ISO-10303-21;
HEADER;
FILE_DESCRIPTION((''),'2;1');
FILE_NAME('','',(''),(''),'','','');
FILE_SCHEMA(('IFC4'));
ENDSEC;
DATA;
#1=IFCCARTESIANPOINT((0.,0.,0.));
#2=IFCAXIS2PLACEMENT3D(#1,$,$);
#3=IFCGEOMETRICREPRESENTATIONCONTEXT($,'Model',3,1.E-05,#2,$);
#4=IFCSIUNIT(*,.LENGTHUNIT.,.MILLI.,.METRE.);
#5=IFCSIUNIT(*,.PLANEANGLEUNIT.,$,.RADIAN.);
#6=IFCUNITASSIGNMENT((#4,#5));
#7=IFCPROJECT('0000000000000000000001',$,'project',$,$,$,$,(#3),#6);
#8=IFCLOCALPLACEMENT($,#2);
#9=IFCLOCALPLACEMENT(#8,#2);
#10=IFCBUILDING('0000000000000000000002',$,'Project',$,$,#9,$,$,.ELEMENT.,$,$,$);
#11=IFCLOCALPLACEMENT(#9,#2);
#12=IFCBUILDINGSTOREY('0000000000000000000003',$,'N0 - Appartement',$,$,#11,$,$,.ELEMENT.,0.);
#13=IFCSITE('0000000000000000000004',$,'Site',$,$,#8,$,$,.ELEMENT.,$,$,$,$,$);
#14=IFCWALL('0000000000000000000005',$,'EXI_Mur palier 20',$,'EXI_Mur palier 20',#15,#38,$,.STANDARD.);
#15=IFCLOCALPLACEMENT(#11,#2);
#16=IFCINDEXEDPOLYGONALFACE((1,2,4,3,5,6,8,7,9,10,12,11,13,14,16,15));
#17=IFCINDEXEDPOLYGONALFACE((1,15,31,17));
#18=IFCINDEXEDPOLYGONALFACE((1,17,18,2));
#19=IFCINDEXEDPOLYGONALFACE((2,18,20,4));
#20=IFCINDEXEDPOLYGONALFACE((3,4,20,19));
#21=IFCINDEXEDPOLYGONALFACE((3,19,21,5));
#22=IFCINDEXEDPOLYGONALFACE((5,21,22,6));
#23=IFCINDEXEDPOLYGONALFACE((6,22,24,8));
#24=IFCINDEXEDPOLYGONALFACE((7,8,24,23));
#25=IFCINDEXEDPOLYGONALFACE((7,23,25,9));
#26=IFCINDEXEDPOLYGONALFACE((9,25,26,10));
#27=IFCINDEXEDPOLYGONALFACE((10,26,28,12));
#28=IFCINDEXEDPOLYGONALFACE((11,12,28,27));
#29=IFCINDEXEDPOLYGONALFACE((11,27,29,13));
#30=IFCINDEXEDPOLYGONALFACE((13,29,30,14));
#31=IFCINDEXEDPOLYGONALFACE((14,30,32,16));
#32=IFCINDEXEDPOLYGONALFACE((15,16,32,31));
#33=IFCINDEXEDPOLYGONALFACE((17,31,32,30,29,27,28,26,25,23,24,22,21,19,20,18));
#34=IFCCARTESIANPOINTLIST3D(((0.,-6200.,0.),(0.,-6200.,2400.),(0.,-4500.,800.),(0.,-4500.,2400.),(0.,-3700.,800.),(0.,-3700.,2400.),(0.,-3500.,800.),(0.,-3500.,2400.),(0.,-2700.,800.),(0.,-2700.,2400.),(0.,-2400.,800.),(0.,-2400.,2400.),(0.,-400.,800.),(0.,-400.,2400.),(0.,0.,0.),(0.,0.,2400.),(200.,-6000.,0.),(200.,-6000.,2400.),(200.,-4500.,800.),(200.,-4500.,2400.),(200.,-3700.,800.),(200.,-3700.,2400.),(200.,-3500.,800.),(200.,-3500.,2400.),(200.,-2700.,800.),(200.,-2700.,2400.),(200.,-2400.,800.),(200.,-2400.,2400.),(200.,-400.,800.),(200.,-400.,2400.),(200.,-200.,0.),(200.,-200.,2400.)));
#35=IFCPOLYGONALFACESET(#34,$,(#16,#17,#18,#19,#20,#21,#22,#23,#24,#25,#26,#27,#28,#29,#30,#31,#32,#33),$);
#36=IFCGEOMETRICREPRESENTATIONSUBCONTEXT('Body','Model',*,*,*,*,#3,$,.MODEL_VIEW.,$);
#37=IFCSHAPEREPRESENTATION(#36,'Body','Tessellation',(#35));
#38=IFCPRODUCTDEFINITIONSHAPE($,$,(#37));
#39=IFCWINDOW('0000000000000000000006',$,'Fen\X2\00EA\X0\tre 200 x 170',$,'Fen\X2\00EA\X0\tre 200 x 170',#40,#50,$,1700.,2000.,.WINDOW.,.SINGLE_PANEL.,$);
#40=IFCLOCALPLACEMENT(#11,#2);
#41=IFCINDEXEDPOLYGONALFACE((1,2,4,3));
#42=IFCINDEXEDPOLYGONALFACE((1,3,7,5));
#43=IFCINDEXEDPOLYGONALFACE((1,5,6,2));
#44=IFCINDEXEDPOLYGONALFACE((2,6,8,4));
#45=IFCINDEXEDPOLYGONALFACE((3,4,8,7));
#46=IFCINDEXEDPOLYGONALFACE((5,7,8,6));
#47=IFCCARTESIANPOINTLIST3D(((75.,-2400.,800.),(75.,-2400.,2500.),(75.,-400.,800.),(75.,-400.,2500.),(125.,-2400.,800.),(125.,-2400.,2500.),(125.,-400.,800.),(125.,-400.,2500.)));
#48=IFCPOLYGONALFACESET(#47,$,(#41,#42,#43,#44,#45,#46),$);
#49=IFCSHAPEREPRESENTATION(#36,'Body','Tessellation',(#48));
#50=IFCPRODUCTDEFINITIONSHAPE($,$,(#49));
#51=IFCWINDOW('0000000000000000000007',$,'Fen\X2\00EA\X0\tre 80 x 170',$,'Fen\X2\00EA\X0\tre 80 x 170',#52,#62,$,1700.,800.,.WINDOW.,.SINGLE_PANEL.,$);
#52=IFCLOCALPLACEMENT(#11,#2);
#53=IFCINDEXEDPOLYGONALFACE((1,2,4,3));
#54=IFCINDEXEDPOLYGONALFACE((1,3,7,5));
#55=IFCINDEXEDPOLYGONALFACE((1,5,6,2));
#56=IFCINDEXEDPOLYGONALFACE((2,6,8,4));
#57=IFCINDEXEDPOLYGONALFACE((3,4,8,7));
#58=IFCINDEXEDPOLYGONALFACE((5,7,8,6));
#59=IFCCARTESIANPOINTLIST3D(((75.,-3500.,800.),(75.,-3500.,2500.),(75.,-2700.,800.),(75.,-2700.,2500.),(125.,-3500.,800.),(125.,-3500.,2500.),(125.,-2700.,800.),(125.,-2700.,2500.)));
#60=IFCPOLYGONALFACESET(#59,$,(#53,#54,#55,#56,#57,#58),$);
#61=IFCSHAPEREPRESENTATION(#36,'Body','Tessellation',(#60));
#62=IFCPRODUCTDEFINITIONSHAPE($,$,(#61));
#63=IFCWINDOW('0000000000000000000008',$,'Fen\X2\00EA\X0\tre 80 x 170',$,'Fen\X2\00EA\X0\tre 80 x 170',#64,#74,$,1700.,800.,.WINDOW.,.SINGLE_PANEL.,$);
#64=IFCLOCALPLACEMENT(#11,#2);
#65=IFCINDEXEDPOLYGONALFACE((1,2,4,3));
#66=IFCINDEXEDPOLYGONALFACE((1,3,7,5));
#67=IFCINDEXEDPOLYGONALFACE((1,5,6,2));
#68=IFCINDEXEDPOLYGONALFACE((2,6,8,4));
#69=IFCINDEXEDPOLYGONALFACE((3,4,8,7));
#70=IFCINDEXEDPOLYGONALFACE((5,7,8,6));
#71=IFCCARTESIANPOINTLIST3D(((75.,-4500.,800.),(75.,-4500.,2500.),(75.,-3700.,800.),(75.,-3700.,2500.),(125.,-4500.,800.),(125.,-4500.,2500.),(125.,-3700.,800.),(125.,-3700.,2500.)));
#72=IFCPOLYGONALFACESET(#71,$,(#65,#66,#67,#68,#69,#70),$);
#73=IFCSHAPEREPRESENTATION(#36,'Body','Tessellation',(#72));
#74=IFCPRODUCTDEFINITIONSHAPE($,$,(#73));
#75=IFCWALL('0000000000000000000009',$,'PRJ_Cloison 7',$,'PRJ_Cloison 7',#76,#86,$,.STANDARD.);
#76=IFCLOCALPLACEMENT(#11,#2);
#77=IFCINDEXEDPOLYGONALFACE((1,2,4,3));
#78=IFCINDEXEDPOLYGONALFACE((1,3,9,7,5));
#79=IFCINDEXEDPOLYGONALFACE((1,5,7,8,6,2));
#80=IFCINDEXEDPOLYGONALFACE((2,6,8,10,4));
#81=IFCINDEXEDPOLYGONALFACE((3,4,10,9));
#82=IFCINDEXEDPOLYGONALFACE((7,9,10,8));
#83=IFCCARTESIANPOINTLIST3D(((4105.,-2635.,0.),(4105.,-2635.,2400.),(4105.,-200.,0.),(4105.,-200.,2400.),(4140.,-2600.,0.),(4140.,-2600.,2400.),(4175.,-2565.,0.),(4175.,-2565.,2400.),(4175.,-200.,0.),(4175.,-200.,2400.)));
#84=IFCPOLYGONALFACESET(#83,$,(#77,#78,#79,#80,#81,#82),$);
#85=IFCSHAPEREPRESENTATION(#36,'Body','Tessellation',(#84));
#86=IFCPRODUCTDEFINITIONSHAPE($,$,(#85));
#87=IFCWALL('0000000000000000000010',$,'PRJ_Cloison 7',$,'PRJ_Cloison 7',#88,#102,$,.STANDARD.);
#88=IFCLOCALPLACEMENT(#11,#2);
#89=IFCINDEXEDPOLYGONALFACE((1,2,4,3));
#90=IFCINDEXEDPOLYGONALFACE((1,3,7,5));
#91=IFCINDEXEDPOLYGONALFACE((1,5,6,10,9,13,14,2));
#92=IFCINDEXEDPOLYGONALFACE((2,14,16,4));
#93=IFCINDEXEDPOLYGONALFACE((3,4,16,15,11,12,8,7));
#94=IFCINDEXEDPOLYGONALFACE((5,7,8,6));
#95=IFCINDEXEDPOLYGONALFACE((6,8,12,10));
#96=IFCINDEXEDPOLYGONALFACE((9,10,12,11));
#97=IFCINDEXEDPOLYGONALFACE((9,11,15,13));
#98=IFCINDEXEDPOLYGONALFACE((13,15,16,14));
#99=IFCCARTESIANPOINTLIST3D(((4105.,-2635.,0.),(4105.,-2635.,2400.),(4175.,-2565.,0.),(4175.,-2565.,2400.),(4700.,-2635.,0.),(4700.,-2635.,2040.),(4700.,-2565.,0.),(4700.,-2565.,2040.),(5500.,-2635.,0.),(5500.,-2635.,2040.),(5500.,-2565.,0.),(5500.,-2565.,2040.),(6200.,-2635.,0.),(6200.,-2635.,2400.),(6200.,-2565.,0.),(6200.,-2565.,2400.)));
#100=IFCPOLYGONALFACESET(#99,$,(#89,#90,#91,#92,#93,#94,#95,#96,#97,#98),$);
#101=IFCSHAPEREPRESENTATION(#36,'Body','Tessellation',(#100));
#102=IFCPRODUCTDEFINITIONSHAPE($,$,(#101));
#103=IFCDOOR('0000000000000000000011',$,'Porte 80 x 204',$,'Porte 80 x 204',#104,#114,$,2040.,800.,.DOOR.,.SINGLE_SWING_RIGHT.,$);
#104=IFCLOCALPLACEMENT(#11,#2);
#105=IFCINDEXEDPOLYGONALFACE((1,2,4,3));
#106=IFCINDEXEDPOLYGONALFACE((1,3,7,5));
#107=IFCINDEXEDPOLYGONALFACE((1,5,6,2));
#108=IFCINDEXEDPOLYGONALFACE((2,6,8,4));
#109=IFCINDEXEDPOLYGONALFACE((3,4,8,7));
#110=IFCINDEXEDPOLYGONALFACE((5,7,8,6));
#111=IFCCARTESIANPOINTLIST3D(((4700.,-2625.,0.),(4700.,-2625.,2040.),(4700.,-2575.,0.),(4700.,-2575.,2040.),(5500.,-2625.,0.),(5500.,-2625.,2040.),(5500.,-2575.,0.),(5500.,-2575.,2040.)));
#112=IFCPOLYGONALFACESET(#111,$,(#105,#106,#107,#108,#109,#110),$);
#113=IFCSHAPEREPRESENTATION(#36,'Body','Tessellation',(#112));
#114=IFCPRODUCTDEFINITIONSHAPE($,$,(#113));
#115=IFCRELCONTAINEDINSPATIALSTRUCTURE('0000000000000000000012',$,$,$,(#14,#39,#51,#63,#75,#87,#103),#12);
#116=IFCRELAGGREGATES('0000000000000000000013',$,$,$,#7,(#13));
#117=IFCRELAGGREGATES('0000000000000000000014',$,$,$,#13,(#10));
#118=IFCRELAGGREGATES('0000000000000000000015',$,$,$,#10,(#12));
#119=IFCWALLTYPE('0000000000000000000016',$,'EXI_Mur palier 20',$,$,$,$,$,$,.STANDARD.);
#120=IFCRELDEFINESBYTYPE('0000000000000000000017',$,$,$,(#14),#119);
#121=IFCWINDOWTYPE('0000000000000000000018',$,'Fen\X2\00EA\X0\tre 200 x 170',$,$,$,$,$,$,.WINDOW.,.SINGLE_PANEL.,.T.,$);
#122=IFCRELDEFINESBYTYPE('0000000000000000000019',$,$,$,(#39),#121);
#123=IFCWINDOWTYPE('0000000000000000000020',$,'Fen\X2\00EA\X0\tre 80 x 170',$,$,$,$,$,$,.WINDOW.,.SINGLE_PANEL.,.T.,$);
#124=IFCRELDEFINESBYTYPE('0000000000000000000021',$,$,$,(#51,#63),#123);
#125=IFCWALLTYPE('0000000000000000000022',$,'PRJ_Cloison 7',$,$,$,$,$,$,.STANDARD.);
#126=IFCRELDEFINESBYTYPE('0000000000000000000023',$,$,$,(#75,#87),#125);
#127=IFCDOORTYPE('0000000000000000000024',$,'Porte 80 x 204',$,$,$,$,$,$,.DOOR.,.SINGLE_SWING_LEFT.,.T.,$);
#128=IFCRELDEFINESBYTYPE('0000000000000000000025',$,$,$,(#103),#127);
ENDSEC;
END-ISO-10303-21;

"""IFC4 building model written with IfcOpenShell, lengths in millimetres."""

from ifc_helpers import new_model, si_unit, frame, frame_2d, origin, place, context, subcontext, project, spatial, polyline, rectangle, outline, extrude, type_object, element, fill, save


model = new_model("IFC4")

# Units and contexts
model_context = context("Model", 3, precision=1e-05, world=origin())
body_context = subcontext(model_context, "Body", "Model", "MODEL_VIEW")
ifc_project = project(units=[si_unit("LENGTHUNIT", "METRE", prefix="MILLI"), si_unit("PLANEANGLEUNIT", "RADIAN")], contexts=[model_context])

# Site, building, storey
site_placement = place(None, origin())
site = spatial("IfcSite", under=ifc_project, at=site_placement, Name="Site", CompositionType="ELEMENT")
building_placement = place(site_placement, origin())
building = spatial("IfcBuilding", under=site, at=building_placement, Name="Project", CompositionType="ELEMENT")
storey_placement = place(building_placement, origin())
storey = spatial("IfcBuildingStorey", under=building, at=storey_placement, Name="N0 - Appartement", CompositionType="ELEMENT", Elevation=0.0)

# Shared definitions
wall_type_1 = type_object("IfcWallType", Name="EXI_Mur palier 20", PredefinedType="STANDARD")

# Shared definitions
window_type_1 = type_object("IfcWindowType", Name="Fenêtre 80 x 170", ParameterTakesPrecedence=True, PartitioningType="SINGLE_PANEL", PredefinedType="WINDOW")

# Wall, openings, windows
wall_1_placement = place(storey_placement, frame((100.0, -6100.0, 0.0), z_axis=(0.0, 0.0, 1.0), x_axis=(0.0, 1.0, 0.0)))
wall_1 = element("IfcWall", 1, at=wall_1_placement, inside=storey, type_object=wall_type_1, Name="EXI_Mur palier 20", ObjectType="EXI_Mur palier 20", PredefinedType="STANDARD", context=body_context, shape_type="SweptSolid", body=[
    extrude(outline(polyline([(100.0, -100.0), (0.0, 0.0), (-100.0, 100.0), (6100.0, 100.0), (6000.0, 0.0), (5900.0, -100.0), (100.0, -100.0)])), origin(), (0.0, 0.0, 1.0), 2400.0),
])
opening_1_placement = place(wall_1_placement, frame((3700.0, 0.0, 800.0), z_axis=(0.0, 0.0, 1.0), x_axis=(1.0, 0.0, 0.0)))
opening_1 = element("IfcOpeningElement", 2, at=opening_1_placement, cuts=wall_1, PredefinedType="OPENING", context=body_context, shape_type="SweptSolid", body=[
    extrude(rectangle(XDim=2000.0, YDim=220.0, at=frame_2d((1000.0, 0.0))), origin(), (0.0, 0.0, 1.0), 1700.0),
])
opening_2_placement = place(wall_1_placement, frame((2600.0, 0.0, 800.0), z_axis=(0.0, 0.0, 1.0), x_axis=(1.0, 0.0, 0.0)))
opening_2 = element("IfcOpeningElement", 3, at=opening_2_placement, cuts=wall_1, PredefinedType="OPENING", context=body_context, shape_type="SweptSolid", body=[
    extrude(rectangle(XDim=800.0, YDim=220.0, at=frame_2d((400.0, 0.0))), origin(), (0.0, 0.0, 1.0), 1700.0),
])
opening_3_placement = place(wall_1_placement, frame((1600.0, 0.0, 800.0), z_axis=(0.0, 0.0, 1.0), x_axis=(1.0, 0.0, 0.0)))
opening_3 = element("IfcOpeningElement", 4, at=opening_3_placement, cuts=wall_1, PredefinedType="OPENING", context=body_context, shape_type="SweptSolid", body=[
    extrude(rectangle(XDim=800.0, YDim=220.0, at=frame_2d((400.0, 0.0))), origin(), (0.0, 0.0, 1.0), 1700.0),
])
window_type_2 = type_object("IfcWindowType", Name="Fenêtre 200 x 170", ParameterTakesPrecedence=True, PartitioningType="SINGLE_PANEL", PredefinedType="WINDOW")
window_1_placement = place(opening_1_placement, origin())
window_1 = element("IfcWindow", 5, at=window_1_placement, inside=storey, type_object=window_type_2, Name="Fenêtre 200 x 170", ObjectType="Fenêtre 200 x 170", OverallHeight=1700.0, OverallWidth=2000.0, PartitioningType="SINGLE_PANEL", PredefinedType="WINDOW", context=body_context, shape_type="SweptSolid", body=[
    extrude(rectangle(XDim=2000.0, YDim=50.0, at=frame_2d((1000.0, 0.0))), origin(), (0.0, 0.0, 1.0), 1700.0),
])
fill(opening_1, window_1)
window_2_placement = place(opening_2_placement, origin())
window_2 = element("IfcWindow", 6, at=window_2_placement, inside=storey, type_object=window_type_1, Name="Fenêtre 80 x 170", ObjectType="Fenêtre 80 x 170", OverallHeight=1700.0, OverallWidth=800.0, PartitioningType="SINGLE_PANEL", PredefinedType="WINDOW", context=body_context, shape_type="SweptSolid", body=[
    extrude(rectangle(XDim=800.0, YDim=50.0, at=frame_2d((400.0, 0.0))), origin(), (0.0, 0.0, 1.0), 1700.0),
])
fill(opening_2, window_2)
window_3_placement = place(opening_3_placement, origin())
window_3 = element("IfcWindow", 7, at=window_3_placement, inside=storey, type_object=window_type_1, Name="Fenêtre 80 x 170", ObjectType="Fenêtre 80 x 170", OverallHeight=1700.0, OverallWidth=800.0, PartitioningType="SINGLE_PANEL", PredefinedType="WINDOW", context=body_context, shape_type="SweptSolid", body=[
    extrude(rectangle(XDim=800.0, YDim=50.0, at=frame_2d((400.0, 0.0))), origin(), (0.0, 0.0, 1.0), 1700.0),
])
fill(opening_3, window_3)

# Wall
wall_type_2 = type_object("IfcWallType", Name="PRJ_Cloison 7", PredefinedType="STANDARD")
wall_2_placement = place(storey_placement, frame((4140.0, -200.0, 0.0), z_axis=(0.0, 0.0, 1.0), x_axis=(0.0, -1.0, 0.0)))
element("IfcWall", 8, at=wall_2_placement, inside=storey, type_object=wall_type_2, Name="PRJ_Cloison 7", ObjectType="PRJ_Cloison 7", PredefinedType="STANDARD", context=body_context, shape_type="SweptSolid", body=[
    extrude(outline(polyline([(0.0, -35.0), (0.0, 35.0), (2365.0, 35.0), (2400.0, 0.0), (2435.0, -35.0), (0.0, -35.0)])), origin(), (0.0, 0.0, 1.0), 2400.0),
])

# Wall, opening, door
wall_3_placement = place(storey_placement, frame((4140.0, -2600.0, 0.0), z_axis=(0.0, 0.0, 1.0), x_axis=(1.0, 0.0, 0.0)))
wall_3 = element("IfcWall", 9, at=wall_3_placement, inside=storey, type_object=wall_type_2, Name="PRJ_Cloison 7", ObjectType="PRJ_Cloison 7", PredefinedType="STANDARD", context=body_context, shape_type="SweptSolid", body=[
    extrude(outline(polyline([(-35.0, -35.0), (0.0, 0.0), (35.0, 35.0), (2060.0, 35.0), (2060.0, -35.0), (-35.0, -35.0)])), origin(), (0.0, 0.0, 1.0), 2400.0),
])
opening_4_placement = place(wall_3_placement, frame((560.0, 0.0, 0.0), z_axis=(0.0, 0.0, 1.0), x_axis=(1.0, 0.0, 0.0)))
opening_4 = element("IfcOpeningElement", 10, at=opening_4_placement, cuts=wall_3, PredefinedType="OPENING", context=body_context, shape_type="SweptSolid", body=[
    extrude(rectangle(XDim=800.0, YDim=90.0, at=frame_2d((400.0, 0.0))), origin(), (0.0, 0.0, 1.0), 2040.0),
])
door_type_1 = type_object("IfcDoorType", Name="Porte 80 x 204", OperationType="SINGLE_SWING_LEFT", ParameterTakesPrecedence=True, PredefinedType="DOOR")
door_1_placement = place(opening_4_placement, origin())
door_1 = element("IfcDoor", 11, at=door_1_placement, inside=storey, type_object=door_type_1, Name="Porte 80 x 204", ObjectType="Porte 80 x 204", OperationType="SINGLE_SWING_RIGHT", OverallHeight=2040.0, OverallWidth=800.0, PredefinedType="DOOR", context=body_context, shape_type="SweptSolid", body=[
    extrude(rectangle(XDim=800.0, YDim=50.0, at=frame_2d((400.0, 0.0))), origin(), (0.0, 0.0, 1.0), 2040.0),
])
fill(opening_4, door_1)

save(model, "model.ifc")
